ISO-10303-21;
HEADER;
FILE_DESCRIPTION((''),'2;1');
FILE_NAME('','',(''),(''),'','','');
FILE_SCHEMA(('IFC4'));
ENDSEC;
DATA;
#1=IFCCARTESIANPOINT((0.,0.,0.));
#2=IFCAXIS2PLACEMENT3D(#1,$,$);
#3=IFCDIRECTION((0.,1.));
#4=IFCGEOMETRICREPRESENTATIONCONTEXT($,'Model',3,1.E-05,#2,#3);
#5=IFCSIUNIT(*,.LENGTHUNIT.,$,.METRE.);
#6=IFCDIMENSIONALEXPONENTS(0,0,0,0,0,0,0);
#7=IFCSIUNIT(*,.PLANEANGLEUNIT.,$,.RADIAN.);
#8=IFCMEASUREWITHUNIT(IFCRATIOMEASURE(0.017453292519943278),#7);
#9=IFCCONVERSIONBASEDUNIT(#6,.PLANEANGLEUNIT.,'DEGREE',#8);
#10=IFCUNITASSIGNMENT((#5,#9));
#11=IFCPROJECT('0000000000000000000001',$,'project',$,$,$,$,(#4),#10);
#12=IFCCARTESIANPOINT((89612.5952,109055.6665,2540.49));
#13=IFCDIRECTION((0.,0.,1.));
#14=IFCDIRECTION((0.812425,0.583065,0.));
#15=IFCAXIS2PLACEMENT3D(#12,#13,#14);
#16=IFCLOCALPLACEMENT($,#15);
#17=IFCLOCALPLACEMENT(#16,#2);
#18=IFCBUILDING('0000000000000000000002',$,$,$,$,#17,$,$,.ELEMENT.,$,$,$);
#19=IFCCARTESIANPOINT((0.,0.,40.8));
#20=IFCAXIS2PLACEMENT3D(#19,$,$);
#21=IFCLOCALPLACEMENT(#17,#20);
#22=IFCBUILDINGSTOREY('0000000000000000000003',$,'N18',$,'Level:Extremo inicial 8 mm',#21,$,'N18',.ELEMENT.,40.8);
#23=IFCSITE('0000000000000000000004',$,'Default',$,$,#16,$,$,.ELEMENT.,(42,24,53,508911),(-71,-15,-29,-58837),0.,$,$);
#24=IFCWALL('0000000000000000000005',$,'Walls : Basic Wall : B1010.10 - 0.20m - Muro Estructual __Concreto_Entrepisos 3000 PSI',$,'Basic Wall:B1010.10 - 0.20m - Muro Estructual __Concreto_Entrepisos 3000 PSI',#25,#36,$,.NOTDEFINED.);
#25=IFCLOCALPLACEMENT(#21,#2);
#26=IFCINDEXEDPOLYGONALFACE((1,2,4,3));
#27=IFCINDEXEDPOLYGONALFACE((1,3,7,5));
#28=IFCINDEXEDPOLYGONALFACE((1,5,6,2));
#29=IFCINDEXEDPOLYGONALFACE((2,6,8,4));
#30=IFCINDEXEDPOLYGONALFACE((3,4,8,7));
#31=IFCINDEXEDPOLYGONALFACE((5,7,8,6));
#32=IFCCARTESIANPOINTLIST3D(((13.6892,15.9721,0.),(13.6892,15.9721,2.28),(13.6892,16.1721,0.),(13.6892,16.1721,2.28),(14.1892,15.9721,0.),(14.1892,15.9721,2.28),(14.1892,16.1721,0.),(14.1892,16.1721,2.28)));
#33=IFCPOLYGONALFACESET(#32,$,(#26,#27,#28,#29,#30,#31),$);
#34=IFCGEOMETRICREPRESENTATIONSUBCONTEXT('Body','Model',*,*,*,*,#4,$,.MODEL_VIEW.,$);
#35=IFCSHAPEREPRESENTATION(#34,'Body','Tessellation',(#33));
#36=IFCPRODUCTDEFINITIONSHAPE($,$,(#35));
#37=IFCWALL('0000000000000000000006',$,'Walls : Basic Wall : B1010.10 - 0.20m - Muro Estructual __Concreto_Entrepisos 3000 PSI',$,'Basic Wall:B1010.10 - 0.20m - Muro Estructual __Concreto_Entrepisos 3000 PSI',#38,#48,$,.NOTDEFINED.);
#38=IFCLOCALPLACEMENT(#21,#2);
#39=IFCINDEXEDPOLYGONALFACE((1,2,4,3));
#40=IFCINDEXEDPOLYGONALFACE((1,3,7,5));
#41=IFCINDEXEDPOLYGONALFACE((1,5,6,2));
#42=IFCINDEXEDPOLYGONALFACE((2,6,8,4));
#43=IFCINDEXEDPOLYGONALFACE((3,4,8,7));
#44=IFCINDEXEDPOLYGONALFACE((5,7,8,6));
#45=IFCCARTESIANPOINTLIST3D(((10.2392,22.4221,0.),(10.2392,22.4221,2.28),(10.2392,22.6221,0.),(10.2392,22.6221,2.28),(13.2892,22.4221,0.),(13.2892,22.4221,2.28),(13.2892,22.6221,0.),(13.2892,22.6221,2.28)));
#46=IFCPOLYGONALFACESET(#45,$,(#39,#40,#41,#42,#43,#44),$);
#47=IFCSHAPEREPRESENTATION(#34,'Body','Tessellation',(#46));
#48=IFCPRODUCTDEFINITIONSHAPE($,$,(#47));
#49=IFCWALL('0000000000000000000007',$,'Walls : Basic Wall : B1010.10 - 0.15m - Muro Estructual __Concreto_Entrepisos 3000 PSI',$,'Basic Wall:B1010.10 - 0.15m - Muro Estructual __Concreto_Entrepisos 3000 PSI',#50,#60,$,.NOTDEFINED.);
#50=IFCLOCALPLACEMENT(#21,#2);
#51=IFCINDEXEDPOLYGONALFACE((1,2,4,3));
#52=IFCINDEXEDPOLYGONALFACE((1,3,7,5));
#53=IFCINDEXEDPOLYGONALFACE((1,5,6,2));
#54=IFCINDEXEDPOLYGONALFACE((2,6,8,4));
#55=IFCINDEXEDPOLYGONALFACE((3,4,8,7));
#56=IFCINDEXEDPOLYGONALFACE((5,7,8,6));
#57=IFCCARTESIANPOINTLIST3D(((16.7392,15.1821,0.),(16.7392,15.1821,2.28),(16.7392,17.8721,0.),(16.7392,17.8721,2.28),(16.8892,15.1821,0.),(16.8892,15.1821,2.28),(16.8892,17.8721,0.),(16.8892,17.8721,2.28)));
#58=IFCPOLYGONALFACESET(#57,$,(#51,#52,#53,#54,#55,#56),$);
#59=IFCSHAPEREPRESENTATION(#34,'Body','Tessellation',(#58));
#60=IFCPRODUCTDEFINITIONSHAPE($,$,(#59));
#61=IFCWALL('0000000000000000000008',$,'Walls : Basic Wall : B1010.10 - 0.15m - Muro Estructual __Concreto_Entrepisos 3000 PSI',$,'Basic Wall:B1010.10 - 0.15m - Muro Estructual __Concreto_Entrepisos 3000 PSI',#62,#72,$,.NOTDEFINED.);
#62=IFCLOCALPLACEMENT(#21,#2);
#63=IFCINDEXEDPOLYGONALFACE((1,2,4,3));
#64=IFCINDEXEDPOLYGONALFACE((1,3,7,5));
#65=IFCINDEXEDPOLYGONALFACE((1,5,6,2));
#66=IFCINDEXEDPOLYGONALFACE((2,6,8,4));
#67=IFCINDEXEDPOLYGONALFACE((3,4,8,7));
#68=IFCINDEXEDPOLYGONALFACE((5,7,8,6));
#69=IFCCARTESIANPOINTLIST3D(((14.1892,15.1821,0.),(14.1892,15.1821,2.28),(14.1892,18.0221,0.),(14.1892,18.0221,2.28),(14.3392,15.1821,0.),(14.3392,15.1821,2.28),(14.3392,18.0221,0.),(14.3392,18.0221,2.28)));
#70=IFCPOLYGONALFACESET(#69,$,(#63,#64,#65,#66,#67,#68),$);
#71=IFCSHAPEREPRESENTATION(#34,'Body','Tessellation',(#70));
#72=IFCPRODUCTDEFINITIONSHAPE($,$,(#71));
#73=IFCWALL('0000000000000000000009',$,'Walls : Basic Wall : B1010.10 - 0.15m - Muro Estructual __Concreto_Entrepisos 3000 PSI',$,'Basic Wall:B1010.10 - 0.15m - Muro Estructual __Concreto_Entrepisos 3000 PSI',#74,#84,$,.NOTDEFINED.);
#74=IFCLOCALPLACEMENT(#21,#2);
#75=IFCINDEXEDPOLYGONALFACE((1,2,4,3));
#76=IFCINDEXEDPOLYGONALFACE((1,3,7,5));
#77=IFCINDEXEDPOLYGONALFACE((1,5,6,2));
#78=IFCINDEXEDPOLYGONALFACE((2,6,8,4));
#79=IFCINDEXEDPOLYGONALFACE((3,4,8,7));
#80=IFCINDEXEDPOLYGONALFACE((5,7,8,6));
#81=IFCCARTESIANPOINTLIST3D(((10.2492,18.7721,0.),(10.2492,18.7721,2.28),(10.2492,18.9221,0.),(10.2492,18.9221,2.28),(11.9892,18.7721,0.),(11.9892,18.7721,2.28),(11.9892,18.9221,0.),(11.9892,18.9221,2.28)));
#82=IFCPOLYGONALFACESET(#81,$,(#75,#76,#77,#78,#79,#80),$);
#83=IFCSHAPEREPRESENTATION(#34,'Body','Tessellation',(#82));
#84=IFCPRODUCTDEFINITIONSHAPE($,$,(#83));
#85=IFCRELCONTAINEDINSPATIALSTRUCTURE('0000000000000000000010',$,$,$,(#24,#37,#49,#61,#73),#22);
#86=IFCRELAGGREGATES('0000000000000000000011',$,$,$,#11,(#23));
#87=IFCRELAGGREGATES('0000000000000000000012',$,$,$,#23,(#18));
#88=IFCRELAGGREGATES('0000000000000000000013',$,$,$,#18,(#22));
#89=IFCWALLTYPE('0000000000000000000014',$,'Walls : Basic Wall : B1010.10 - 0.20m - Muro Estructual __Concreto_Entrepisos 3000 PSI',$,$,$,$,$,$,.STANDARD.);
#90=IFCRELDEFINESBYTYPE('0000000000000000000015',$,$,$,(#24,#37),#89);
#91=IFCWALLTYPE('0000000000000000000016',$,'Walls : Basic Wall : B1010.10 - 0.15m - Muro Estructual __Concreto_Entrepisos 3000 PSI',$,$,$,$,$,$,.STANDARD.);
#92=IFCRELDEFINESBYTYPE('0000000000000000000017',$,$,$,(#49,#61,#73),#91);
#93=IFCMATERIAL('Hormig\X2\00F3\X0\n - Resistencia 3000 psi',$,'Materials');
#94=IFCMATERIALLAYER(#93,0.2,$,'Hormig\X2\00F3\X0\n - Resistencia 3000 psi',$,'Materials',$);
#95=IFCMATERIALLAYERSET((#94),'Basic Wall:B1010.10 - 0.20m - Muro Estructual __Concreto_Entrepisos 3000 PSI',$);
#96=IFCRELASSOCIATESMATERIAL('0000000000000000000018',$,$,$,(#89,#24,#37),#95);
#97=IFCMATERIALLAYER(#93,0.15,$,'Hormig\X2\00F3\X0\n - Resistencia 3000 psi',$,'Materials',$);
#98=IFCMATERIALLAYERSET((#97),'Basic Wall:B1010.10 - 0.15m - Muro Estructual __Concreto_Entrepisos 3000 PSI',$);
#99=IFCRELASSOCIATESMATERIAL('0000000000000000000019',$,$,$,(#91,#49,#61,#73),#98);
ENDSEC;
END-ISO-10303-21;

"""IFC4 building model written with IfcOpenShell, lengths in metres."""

from ifc_helpers import new_model, entity, si_unit, converted_unit, direction, frame, frame_2d, origin, place, context, subcontext, project, spatial, rectangle, extrude, material, layer, layer_set, layer_usage, type_object, element, save


model = new_model("IFC4")

# Units and contexts
model_context = context("Model", 3, precision=1e-05, world=origin(), true_north=direction((0.0, 1.0)))
body_context = subcontext(model_context, "Body", "Model", "MODEL_VIEW")
ifc_project = project(units=[si_unit("LENGTHUNIT", "METRE"), converted_unit("PLANEANGLEUNIT", "DEGREE", entity("IfcRatioMeasure", 0.017453292519943278), si_unit("PLANEANGLEUNIT", "RADIAN"), dimensions=[0, 0, 0, 0, 0, 0, 0])], contexts=[model_context])

# Site, building, storey
site_placement = place(None, frame((89612.5952, 109055.6665, 2540.49), z_axis=(0.0, 0.0, 1.0), x_axis=(0.812425, 0.583065, 0.0)))
site = spatial("IfcSite", under=ifc_project, at=site_placement, Name="Default", CompositionType="ELEMENT", RefLatitude=(42, 24, 53, 508911), RefLongitude=(-71, -15, -29, -58837), RefElevation=0.0)
building_placement = place(site_placement, origin())
building = spatial("IfcBuilding", under=site, at=building_placement, CompositionType="ELEMENT")
storey_placement = place(building_placement, frame((0.0, 0.0, 40.8)))
storey = spatial("IfcBuildingStorey", under=building, at=storey_placement, Name="N18", ObjectType="Level:Extremo inicial 8 mm", LongName="N18", CompositionType="ELEMENT", Elevation=40.8)

# Walls
ifc_material_1 = material(Name="Hormigón - Resistencia 3000 psi", Category="Materials")
ifc_layer_1 = layer(ifc_material_1, 0.2, Name="Hormigón - Resistencia 3000 psi", Category="Materials")
ifc_layer_set_1 = layer_set([ifc_layer_1], Name="Basic Wall:B1010.10 - 0.20m - Muro Estructual __Concreto_Entrepisos 3000 PSI")
wall_type_1 = type_object("IfcWallType", Name="Walls : Basic Wall : B1010.10 - 0.20m - Muro Estructual __Concreto_Entrepisos 3000 PSI", PredefinedType="STANDARD", material=ifc_layer_set_1)
ifc_layer_usage_1 = layer_usage(ifc_layer_set_1, "AXIS2", "NEGATIVE", 0.1)
wall_1_placement = place(storey_placement, frame((13.6892, 16.0721, 0.0)))
element("IfcWall", 1, at=wall_1_placement, inside=storey, type_object=wall_type_1, material=ifc_layer_usage_1, Name="Walls : Basic Wall : B1010.10 - 0.20m - Muro Estructual __Concreto_Entrepisos 3000 PSI", ObjectType="Basic Wall:B1010.10 - 0.20m - Muro Estructual __Concreto_Entrepisos 3000 PSI", PredefinedType="NOTDEFINED", context=body_context, shape_type="SweptSolid", body=[
    extrude(rectangle(XDim=0.5, YDim=0.2, at=frame_2d((0.25, 0.0), x_axis=(-1.0, 0.0))), origin(), (0.0, 0.0, 1.0), 2.28),
])
ifc_layer_usage_2 = layer_usage(ifc_layer_set_1, "AXIS2", "POSITIVE", -0.1)
wall_2_placement = place(storey_placement, frame((10.2392, 22.5221, 0.0)))
element("IfcWall", 2, at=wall_2_placement, inside=storey, type_object=wall_type_1, material=ifc_layer_usage_2, Name="Walls : Basic Wall : B1010.10 - 0.20m - Muro Estructual __Concreto_Entrepisos 3000 PSI", ObjectType="Basic Wall:B1010.10 - 0.20m - Muro Estructual __Concreto_Entrepisos 3000 PSI", PredefinedType="NOTDEFINED", context=body_context, shape_type="SweptSolid", body=[
    extrude(rectangle(XDim=3.05, YDim=0.2, at=frame_2d((1.525, 0.0), x_axis=(-1.0, 0.0))), origin(), (0.0, 0.0, 1.0), 2.28),
])
ifc_layer_2 = layer(ifc_material_1, 0.15, Name="Hormigón - Resistencia 3000 psi", Category="Materials")
ifc_layer_set_2 = layer_set([ifc_layer_2], Name="Basic Wall:B1010.10 - 0.15m - Muro Estructual __Concreto_Entrepisos 3000 PSI")
ifc_layer_usage_3 = layer_usage(ifc_layer_set_2, "AXIS2", "NEGATIVE", 0.075)
wall_type_2 = type_object("IfcWallType", Name="Walls : Basic Wall : B1010.10 - 0.15m - Muro Estructual __Concreto_Entrepisos 3000 PSI", PredefinedType="STANDARD", material=ifc_layer_set_2)
wall_3_placement = place(storey_placement, frame((16.8142, 15.1821, 0.0), z_axis=(0.0, 0.0, 1.0), x_axis=(0.0, 1.0, 0.0)))
element("IfcWall", 3, at=wall_3_placement, inside=storey, type_object=wall_type_2, material=ifc_layer_usage_3, Name="Walls : Basic Wall : B1010.10 - 0.15m - Muro Estructual __Concreto_Entrepisos 3000 PSI", ObjectType="Basic Wall:B1010.10 - 0.15m - Muro Estructual __Concreto_Entrepisos 3000 PSI", PredefinedType="NOTDEFINED", context=body_context, shape_type="SweptSolid", body=[
    extrude(rectangle(XDim=2.69, YDim=0.15, at=frame_2d((1.345, 0.0), x_axis=(-1.0, 0.0))), origin(), (0.0, 0.0, 1.0), 2.28),
])
ifc_layer_usage_4 = layer_usage(ifc_layer_set_2, "AXIS2", "NEGATIVE", 0.075)
wall_4_placement = place(storey_placement, frame((14.2642, 15.1821, 0.0), z_axis=(0.0, 0.0, 1.0), x_axis=(0.0, 1.0, 0.0)))
element("IfcWall", 4, at=wall_4_placement, inside=storey, type_object=wall_type_2, material=ifc_layer_usage_4, Name="Walls : Basic Wall : B1010.10 - 0.15m - Muro Estructual __Concreto_Entrepisos 3000 PSI", ObjectType="Basic Wall:B1010.10 - 0.15m - Muro Estructual __Concreto_Entrepisos 3000 PSI", PredefinedType="NOTDEFINED", context=body_context, shape_type="SweptSolid", body=[
    extrude(rectangle(XDim=2.84, YDim=0.15, at=frame_2d((1.42, 0.0), x_axis=(-1.0, 0.0))), origin(), (0.0, 0.0, 1.0), 2.28),
])
ifc_layer_usage_5 = layer_usage(ifc_layer_set_2, "AXIS2", "NEGATIVE", 0.075)
wall_5_placement = place(storey_placement, frame((11.9892, 18.8471, 0.0), z_axis=(0.0, 0.0, 1.0), x_axis=(-1.0, 0.0, 0.0)))
element("IfcWall", 5, at=wall_5_placement, inside=storey, type_object=wall_type_2, material=ifc_layer_usage_5, Name="Walls : Basic Wall : B1010.10 - 0.15m - Muro Estructual __Concreto_Entrepisos 3000 PSI", ObjectType="Basic Wall:B1010.10 - 0.15m - Muro Estructual __Concreto_Entrepisos 3000 PSI", PredefinedType="NOTDEFINED", context=body_context, shape_type="SweptSolid", body=[
    extrude(rectangle(XDim=1.74, YDim=0.15, at=frame_2d((0.87, 0.0), x_axis=(-1.0, 0.0))), origin(), (0.0, 0.0, 1.0), 2.28),
])

save(model, "model.ifc")
